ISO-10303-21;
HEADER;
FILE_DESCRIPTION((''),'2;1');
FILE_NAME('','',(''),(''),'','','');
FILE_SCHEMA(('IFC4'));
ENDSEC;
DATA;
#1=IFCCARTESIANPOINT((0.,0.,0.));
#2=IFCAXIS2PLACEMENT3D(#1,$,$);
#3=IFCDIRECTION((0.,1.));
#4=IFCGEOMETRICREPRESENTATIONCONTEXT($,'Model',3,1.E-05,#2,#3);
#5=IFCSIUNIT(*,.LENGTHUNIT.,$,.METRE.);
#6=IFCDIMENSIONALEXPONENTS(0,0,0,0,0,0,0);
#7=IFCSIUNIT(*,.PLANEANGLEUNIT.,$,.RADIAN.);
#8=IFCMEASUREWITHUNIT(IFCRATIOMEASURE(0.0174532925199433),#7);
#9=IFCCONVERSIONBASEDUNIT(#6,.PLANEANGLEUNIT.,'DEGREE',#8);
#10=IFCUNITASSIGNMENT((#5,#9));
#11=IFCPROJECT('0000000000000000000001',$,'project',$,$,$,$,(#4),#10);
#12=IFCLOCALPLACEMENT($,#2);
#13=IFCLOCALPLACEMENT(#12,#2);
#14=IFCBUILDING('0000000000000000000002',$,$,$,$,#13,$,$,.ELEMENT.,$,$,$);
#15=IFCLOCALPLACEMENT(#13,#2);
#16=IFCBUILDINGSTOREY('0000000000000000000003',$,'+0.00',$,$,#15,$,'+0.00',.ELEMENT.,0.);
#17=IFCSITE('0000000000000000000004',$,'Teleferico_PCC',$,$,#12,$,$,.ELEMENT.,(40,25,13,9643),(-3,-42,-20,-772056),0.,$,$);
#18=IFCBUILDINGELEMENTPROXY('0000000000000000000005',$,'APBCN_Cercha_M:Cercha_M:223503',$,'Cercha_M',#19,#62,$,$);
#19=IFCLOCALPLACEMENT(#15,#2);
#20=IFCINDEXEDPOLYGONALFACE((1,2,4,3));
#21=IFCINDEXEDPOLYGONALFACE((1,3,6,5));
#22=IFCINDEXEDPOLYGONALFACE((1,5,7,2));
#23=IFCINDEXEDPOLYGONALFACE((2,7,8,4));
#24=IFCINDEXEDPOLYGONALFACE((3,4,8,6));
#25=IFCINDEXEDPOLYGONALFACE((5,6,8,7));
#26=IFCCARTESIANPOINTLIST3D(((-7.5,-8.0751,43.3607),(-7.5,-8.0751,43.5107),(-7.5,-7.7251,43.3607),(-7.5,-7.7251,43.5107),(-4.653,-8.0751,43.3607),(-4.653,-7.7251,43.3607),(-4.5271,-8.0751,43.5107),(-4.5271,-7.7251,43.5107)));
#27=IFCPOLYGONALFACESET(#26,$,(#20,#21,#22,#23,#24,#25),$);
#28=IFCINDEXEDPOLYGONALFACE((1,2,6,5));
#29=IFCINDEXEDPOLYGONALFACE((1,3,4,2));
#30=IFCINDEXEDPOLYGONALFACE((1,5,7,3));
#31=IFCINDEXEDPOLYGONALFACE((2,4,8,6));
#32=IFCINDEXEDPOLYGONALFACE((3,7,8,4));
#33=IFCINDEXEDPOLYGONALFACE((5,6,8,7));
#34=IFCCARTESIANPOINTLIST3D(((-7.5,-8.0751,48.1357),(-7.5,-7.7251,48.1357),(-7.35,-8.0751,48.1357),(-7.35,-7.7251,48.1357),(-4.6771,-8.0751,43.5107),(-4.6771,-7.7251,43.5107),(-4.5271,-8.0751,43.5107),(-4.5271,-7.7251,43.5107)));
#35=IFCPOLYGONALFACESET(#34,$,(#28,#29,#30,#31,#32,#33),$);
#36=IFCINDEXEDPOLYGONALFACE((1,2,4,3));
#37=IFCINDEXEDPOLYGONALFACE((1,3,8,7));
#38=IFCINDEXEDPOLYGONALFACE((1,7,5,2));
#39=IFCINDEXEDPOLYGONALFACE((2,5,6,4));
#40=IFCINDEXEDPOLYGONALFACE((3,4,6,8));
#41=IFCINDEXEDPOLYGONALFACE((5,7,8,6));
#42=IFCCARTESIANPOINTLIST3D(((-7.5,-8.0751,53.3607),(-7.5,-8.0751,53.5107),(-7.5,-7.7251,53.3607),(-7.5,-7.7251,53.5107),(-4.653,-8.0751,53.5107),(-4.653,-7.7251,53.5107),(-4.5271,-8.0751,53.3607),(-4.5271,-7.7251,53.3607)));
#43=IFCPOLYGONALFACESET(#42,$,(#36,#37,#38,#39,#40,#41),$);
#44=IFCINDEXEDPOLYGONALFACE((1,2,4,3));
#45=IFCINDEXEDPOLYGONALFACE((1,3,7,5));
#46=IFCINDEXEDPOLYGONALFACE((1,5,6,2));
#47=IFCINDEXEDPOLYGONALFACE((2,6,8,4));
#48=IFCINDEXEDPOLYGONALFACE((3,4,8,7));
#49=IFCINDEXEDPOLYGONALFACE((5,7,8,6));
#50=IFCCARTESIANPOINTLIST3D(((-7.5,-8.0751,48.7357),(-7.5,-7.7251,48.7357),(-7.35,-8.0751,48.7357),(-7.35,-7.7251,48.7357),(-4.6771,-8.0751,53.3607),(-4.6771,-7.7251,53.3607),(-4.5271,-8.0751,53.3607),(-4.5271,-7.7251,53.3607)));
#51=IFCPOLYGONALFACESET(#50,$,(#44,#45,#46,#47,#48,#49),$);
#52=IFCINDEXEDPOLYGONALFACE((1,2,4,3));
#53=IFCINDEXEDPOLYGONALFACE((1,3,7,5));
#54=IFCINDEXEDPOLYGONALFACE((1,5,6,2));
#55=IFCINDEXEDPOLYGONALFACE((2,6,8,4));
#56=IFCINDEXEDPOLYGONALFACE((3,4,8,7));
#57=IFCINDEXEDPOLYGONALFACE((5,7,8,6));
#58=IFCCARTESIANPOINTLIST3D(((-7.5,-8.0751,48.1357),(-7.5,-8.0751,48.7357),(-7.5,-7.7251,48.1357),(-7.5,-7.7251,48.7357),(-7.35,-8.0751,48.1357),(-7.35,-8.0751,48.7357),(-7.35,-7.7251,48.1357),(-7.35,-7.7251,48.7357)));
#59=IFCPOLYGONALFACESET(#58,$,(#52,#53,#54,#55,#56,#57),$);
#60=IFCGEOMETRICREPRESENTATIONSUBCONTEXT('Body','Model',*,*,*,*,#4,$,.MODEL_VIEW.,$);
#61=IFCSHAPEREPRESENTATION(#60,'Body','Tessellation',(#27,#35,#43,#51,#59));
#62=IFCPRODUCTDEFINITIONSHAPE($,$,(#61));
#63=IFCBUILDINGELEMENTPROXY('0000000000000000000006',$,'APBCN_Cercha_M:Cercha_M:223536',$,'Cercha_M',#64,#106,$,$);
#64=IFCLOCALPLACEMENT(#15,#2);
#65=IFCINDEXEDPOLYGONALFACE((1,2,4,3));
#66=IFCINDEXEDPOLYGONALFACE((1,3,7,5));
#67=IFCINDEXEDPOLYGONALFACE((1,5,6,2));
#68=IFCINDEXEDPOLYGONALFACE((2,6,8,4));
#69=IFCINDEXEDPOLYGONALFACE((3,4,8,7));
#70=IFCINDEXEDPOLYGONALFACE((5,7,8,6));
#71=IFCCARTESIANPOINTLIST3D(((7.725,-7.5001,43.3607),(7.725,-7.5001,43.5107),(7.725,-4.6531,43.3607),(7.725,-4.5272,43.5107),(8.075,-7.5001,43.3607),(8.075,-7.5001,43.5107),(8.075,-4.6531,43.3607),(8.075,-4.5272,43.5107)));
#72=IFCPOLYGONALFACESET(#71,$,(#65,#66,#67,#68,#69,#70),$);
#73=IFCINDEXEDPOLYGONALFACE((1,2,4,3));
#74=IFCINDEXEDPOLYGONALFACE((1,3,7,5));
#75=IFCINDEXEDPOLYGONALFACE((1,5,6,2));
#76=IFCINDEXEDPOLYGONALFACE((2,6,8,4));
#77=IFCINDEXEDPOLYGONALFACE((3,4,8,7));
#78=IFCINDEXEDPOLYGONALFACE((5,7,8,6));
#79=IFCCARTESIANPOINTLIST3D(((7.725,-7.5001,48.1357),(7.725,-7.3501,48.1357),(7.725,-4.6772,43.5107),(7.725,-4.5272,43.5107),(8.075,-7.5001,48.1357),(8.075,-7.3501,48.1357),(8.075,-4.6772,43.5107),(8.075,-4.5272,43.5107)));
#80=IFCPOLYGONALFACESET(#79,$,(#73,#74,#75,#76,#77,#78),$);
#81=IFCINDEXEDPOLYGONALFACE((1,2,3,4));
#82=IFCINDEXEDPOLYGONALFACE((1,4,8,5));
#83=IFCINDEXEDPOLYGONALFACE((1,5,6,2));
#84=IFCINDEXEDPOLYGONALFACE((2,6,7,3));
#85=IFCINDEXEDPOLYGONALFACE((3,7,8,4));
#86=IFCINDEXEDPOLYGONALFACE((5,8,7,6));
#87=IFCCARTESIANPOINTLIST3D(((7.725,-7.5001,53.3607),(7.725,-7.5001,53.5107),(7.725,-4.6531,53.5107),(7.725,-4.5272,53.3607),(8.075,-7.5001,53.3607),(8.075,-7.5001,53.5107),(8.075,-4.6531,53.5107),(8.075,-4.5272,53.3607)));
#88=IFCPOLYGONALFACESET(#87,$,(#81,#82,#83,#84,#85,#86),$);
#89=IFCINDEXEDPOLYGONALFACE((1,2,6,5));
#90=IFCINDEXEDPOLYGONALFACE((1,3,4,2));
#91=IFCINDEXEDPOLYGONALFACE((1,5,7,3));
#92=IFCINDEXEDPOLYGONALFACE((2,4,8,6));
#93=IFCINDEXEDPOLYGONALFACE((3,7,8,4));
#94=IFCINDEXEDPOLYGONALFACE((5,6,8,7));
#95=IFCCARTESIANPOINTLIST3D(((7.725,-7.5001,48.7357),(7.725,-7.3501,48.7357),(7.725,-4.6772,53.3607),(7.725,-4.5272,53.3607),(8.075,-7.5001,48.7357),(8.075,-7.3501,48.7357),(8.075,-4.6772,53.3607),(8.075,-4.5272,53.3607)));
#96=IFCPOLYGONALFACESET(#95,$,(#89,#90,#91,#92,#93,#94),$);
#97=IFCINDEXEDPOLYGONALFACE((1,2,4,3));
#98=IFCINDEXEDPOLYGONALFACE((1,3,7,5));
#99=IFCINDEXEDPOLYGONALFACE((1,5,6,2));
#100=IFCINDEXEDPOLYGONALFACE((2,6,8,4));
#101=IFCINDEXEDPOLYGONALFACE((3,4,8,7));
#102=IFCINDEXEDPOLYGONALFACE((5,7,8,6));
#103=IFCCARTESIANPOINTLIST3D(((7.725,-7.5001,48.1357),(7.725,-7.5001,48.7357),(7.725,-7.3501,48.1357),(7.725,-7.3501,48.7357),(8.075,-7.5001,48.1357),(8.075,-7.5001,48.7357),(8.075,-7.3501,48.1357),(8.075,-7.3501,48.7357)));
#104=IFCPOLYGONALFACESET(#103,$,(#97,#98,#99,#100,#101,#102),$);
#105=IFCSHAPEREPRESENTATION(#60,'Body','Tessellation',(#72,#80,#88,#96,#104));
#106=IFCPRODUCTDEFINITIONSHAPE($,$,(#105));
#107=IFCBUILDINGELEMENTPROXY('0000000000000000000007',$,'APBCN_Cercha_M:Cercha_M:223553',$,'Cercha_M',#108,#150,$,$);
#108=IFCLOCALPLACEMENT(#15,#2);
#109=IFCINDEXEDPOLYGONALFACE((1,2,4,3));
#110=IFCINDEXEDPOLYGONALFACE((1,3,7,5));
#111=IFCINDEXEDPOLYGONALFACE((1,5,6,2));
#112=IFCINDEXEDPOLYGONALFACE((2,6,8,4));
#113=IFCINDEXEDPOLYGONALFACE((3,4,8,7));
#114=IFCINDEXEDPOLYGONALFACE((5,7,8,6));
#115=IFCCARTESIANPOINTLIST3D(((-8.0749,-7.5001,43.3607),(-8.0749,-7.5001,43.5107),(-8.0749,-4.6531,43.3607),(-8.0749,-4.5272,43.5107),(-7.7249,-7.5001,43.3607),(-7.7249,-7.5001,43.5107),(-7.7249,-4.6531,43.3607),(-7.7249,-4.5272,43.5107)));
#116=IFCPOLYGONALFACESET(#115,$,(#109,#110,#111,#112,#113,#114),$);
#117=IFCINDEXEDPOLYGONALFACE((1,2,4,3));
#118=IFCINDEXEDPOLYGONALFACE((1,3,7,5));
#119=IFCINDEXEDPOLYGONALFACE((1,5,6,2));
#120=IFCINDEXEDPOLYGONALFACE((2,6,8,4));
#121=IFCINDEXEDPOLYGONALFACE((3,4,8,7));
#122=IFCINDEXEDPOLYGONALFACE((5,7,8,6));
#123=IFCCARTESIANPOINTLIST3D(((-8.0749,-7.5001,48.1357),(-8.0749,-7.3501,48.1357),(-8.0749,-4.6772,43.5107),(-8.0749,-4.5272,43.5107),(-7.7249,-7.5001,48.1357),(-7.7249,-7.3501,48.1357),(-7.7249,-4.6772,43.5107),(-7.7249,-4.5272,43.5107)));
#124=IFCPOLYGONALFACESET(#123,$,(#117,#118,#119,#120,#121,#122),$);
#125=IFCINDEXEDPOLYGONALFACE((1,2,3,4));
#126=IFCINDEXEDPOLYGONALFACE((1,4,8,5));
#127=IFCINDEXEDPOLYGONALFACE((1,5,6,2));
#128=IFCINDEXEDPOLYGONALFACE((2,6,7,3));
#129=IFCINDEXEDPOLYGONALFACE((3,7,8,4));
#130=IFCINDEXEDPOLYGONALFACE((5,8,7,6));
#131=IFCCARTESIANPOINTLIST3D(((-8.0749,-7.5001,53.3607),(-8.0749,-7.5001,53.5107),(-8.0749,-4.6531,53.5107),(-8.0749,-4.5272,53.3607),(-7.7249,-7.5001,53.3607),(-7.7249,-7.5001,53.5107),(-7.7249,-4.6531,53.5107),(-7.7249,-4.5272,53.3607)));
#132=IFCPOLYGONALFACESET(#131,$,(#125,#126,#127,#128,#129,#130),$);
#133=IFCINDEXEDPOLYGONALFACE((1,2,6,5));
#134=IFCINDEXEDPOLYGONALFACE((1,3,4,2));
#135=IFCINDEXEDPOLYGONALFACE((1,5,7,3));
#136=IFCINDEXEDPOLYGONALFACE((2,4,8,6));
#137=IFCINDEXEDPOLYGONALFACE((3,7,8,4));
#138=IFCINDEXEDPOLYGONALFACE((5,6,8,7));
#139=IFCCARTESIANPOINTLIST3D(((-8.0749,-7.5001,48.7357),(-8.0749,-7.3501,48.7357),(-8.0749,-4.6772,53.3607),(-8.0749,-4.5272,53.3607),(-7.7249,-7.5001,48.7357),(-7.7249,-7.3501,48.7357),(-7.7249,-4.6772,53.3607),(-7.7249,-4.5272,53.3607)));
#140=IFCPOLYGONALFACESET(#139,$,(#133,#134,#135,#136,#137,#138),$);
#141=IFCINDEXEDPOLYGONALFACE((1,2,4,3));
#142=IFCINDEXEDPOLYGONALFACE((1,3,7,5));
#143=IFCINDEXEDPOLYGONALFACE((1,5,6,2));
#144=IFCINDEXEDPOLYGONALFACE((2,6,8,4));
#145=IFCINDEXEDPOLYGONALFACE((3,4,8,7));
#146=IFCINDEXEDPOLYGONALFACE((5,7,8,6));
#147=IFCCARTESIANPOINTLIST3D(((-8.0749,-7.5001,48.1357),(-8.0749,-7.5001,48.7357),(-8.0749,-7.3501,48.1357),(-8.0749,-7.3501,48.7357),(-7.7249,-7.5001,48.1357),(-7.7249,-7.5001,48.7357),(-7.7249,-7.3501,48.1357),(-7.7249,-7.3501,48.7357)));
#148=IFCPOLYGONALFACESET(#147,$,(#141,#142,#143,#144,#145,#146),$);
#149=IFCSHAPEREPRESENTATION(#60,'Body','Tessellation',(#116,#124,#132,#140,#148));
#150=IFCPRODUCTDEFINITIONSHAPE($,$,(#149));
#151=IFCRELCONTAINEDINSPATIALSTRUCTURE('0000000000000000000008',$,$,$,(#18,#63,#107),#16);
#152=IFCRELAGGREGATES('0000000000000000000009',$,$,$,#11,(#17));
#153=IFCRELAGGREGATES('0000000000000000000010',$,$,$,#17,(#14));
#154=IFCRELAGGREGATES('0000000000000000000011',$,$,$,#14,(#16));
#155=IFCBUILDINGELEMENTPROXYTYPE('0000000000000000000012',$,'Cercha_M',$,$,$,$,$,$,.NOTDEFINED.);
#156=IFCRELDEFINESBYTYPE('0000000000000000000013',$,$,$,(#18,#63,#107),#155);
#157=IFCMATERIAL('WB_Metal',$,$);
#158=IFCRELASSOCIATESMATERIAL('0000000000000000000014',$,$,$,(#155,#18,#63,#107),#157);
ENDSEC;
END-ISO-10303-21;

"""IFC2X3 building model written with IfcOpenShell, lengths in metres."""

from ifc_helpers import new_model, entity, si_unit, converted_unit, direction, frame, origin, origin_2d_with_axis, place, context, subcontext, project, spatial, polyline, rectangle, outline, extrude, source, transform, mapped, material, type_object, type_shapes, element, save


model = new_model("IFC2X3")

# Units and contexts
model_context = context("Model", 3, precision=1e-05, world=origin(), true_north=direction((0.0, 1.0)))
body_context = subcontext(model_context, "Body", "Model", "MODEL_VIEW")
ifc_project = project(units=[si_unit("LENGTHUNIT", "METRE"), converted_unit("PLANEANGLEUNIT", "DEGREE", entity("IfcRatioMeasure", 0.0174532925199433), si_unit("PLANEANGLEUNIT", "RADIAN"), dimensions=[0, 0, 0, 0, 0, 0, 0])], contexts=[model_context])

# Site, building, storey
site_placement = place(None, origin())
site = spatial("IfcSite", under=ifc_project, at=site_placement, Name="Teleferico_PCC", CompositionType="ELEMENT", RefLatitude=(40, 25, 13, 9643), RefLongitude=(-3, -42, -20, -772056), RefElevation=0.0)
building_placement = place(site_placement, origin())
building = spatial("IfcBuilding", under=site, at=building_placement, CompositionType="ELEMENT")
storey_placement = place(building_placement, origin())
storey = spatial("IfcBuildingStorey", under=building, at=storey_placement, Name="+0.00", LongName="+0.00", CompositionType="ELEMENT", Elevation=0.0)

# Shared definitions
ifc_material_1 = material(Name="WB_Metal")

# Building element proxies
building_element_proxy_type_1 = type_object("IfcBuildingElementProxyType", Name="Cercha_M", PredefinedType="NOTDEFINED", material=ifc_material_1)
shared_shape_1 = source(origin(), body_context, "Body", "SweptSolid", [
    extrude(outline(polyline([(-0.075, -1.455), (0.075, -1.455), (0.075, 1.3921), (-0.075, 1.5179), (-0.075, -1.455)])), frame((-1.455, -0.175, -5.0), z_axis=(0.0, 1.0, 0.0), x_axis=(0.0, 0.0, -1.0)), (0.0, 0.0, 1.0), 0.35),
    extrude(outline(polyline([(1.3365, -2.3125), (1.4865, -2.3125), (-1.3365, 2.3125), (-1.4865, 2.3125), (1.3365, -2.3125)])), frame((-1.4865, -0.175, -2.6125), z_axis=(0.0, 1.0, 0.0), x_axis=(1.0, 0.0, 0.0)), (0.0, 0.0, 1.0), 0.35),
    extrude(outline(polyline([(-0.075, -1.455), (0.075, -1.455), (0.075, 1.5179), (-0.075, 1.3921), (-0.075, -1.455)])), frame((-1.455, -0.175, 5.0), z_axis=(0.0, 1.0, 0.0), x_axis=(0.0, 0.0, -1.0)), (0.0, 0.0, 1.0), 0.35),
    extrude(outline(polyline([(-2.6701, -0.064), (2.7483, -0.064), (2.6701, 0.064), (-2.7483, 0.064), (-2.6701, -0.064)])), frame((-1.4865, -0.175, 2.6125), z_axis=(0.0, 1.0, 0.0), x_axis=(-0.520985, 0.0, 0.853566)), (0.0, 0.0, 1.0), 0.35),
    extrude(rectangle(XDim=0.15, YDim=0.35, at=origin_2d_with_axis()), frame((-0.075, 0.0, -0.3), z_axis=(0.0, 0.0, 1.0), x_axis=(-1.0, 0.0, 0.0)), (0.0, 0.0, 1.0), 0.6),
])
type_shapes(building_element_proxy_type_1, [shared_shape_1])
for number, where, z_axis, x_axis, name in (
    (1, (-7.5, -7.9001, 48.4357), (0.0, 0.0, 1.0), (-1.0, 0.0, 0.0), "APBCN_Cercha_M:Cercha_M:223503"),
    (2, (7.9, -7.5001, 48.4357), (0.0, 0.0, 1.0), (0.0, -1.0, 0.0), "APBCN_Cercha_M:Cercha_M:223536"),
    (3, (-7.8999, -7.5001, 48.4357), (0.0, 0.0, 1.0), (0.0, -1.0, 0.0), "APBCN_Cercha_M:Cercha_M:223553"),
):
    element("IfcBuildingElementProxy", number, at=place(storey_placement, frame(where, z_axis=z_axis, x_axis=x_axis)), inside=storey, type_object=building_element_proxy_type_1, material=ifc_material_1, Name=name, ObjectType="Cercha_M", context=body_context, shape_type="MappedRepresentation", body=[
        mapped(shared_shape_1, transform((0.0, 0.0, 0.0), scale=1.0)),
    ])

save(model, "model.ifc")
